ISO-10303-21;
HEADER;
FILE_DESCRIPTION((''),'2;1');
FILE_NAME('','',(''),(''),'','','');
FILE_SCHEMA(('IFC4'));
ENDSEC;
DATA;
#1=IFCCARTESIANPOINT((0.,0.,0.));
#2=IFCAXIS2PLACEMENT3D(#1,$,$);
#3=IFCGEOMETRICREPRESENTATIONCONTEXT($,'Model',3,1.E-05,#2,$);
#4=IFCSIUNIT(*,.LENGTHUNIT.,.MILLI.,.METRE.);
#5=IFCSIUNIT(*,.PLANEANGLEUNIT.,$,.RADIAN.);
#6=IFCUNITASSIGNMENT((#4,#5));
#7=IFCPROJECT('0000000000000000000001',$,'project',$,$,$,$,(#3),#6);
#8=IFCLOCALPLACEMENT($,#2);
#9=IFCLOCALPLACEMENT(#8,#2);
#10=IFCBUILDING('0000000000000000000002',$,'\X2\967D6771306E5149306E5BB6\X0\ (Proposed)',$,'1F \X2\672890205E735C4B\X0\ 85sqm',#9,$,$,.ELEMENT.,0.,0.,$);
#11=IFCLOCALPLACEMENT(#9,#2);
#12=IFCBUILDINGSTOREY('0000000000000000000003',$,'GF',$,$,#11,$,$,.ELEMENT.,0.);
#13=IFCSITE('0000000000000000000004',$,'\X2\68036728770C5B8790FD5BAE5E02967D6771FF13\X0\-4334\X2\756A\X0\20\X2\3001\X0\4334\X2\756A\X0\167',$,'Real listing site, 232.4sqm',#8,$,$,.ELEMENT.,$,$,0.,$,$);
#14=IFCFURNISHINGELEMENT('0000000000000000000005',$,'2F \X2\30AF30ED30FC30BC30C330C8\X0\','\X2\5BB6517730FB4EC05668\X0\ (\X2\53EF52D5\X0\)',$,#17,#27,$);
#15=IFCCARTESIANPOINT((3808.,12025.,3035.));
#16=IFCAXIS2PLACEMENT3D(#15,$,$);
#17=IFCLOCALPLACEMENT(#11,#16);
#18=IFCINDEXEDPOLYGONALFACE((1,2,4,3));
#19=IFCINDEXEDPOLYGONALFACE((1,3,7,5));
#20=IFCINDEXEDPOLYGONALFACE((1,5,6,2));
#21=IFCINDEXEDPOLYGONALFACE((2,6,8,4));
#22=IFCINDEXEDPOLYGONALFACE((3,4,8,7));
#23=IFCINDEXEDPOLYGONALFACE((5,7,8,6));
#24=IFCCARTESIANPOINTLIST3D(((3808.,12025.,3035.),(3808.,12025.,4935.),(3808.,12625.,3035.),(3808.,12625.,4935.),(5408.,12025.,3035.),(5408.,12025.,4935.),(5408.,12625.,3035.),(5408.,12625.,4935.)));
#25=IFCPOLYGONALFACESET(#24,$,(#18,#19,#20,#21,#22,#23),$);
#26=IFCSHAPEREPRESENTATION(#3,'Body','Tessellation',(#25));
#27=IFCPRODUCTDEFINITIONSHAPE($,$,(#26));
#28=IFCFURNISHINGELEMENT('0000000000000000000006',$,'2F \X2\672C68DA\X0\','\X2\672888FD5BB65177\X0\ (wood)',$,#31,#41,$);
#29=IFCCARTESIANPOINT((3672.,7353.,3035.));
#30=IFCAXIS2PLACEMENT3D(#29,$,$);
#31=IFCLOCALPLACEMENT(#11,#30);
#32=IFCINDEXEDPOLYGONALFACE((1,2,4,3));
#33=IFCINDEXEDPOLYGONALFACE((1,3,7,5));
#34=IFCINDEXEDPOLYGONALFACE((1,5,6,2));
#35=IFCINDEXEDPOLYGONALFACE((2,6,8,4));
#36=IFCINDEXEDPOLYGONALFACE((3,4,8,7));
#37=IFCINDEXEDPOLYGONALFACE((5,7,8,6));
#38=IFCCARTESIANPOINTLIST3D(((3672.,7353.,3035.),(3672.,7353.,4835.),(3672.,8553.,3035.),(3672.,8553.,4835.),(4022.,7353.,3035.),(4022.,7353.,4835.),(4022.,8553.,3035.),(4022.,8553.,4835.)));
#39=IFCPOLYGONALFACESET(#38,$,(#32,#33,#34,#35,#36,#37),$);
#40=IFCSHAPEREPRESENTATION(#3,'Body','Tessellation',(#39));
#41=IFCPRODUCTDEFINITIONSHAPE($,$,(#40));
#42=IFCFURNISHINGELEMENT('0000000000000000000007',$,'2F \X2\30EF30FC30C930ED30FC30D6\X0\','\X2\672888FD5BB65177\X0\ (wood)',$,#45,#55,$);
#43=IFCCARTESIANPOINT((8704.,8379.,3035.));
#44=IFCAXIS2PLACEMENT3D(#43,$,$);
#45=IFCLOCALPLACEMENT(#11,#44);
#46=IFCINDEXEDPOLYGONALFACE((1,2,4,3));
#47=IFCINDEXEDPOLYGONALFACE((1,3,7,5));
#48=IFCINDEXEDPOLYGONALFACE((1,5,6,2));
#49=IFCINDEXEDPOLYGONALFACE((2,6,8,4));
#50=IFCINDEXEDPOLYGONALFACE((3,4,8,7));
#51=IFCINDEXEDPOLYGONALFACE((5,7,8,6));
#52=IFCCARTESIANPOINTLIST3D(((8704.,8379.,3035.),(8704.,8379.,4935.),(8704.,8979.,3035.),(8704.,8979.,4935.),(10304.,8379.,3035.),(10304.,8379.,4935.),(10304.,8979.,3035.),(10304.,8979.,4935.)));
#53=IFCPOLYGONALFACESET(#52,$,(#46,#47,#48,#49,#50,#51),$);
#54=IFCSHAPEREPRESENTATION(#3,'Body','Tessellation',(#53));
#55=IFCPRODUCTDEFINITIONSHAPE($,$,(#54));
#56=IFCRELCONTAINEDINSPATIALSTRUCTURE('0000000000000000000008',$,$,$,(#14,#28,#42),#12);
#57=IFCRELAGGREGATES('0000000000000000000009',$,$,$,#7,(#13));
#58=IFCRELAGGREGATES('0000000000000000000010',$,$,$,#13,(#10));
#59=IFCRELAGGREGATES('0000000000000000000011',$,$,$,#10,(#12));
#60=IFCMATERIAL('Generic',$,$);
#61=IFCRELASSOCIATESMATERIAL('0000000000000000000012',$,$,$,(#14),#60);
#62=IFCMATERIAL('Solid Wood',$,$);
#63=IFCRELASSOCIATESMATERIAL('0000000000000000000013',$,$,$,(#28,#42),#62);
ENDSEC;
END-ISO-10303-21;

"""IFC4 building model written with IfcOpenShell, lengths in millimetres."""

from ifc_helpers import new_model, si_unit, frame, frame_2d, origin, place, context, project, spatial, rectangle, extrude, material, element, save


model = new_model("IFC4")

# Units and contexts
model_context = context("Model", 3, precision=1e-05, world=origin())
ifc_project = project(units=[si_unit("LENGTHUNIT", "METRE", prefix="MILLI"), si_unit("PLANEANGLEUNIT", "RADIAN")], contexts=[model_context])

# Site, building, storey
site_placement = place(None, origin())
site = spatial("IfcSite", under=ifc_project, at=site_placement, Name="栃木県宇都宮市陽東３-4334番20、4334番167", ObjectType="Real listing site, 232.4sqm", CompositionType="ELEMENT", RefElevation=0.0)
building_placement = place(site_placement, origin())
building = spatial("IfcBuilding", under=site, at=building_placement, Name="陽東の光の家 (Proposed)", ObjectType="1F 木造平屋 85sqm", CompositionType="ELEMENT", ElevationOfRefHeight=0.0, ElevationOfTerrain=0.0)
storey_placement = place(building_placement, origin())
storey = spatial("IfcBuildingStorey", under=building, at=storey_placement, Name="GF", CompositionType="ELEMENT", Elevation=0.0)

# Shared definitions
ifc_material_1 = material(Name="Solid Wood")

# Shared definitions
ifc_material_2 = material(Name="Generic")

# Furnishing elements
furnishing_1_placement = place(storey_placement, frame((3808.0, 12025.0, 3035.0)))
element("IfcFurnishingElement", 1, at=furnishing_1_placement, inside=storey, material=ifc_material_2, Name="2F クローゼット", Description="家具・什器 (可動)", context=model_context, shape_type="SweptSolid", body=[
    extrude(rectangle(XDim=1600.0, YDim=600.0, at=frame_2d((800.0, 300.0))), frame((3808.0, 12025.0, 3035.0)), (0.0, 0.0, 1.0), 1900.0),
])
furnishing_2_placement = place(storey_placement, frame((3672.0, 7353.0, 3035.0)))
element("IfcFurnishingElement", 2, at=furnishing_2_placement, inside=storey, material=ifc_material_1, Name="2F 本棚", Description="木製家具 (wood)", context=model_context, shape_type="SweptSolid", body=[
    extrude(rectangle(XDim=350.0, YDim=1200.0, at=frame_2d((175.0, 600.0))), frame((3672.0, 7353.0, 3035.0)), (0.0, 0.0, 1.0), 1800.0),
])
furnishing_3_placement = place(storey_placement, frame((8704.0, 8379.0, 3035.0)))
element("IfcFurnishingElement", 3, at=furnishing_3_placement, inside=storey, material=ifc_material_1, Name="2F ワードローブ", Description="木製家具 (wood)", context=model_context, shape_type="SweptSolid", body=[
    extrude(rectangle(XDim=1600.0, YDim=600.0, at=frame_2d((800.0, 300.0))), frame((8704.0, 8379.0, 3035.0)), (0.0, 0.0, 1.0), 1900.0),
])

save(model, "model.ifc")
